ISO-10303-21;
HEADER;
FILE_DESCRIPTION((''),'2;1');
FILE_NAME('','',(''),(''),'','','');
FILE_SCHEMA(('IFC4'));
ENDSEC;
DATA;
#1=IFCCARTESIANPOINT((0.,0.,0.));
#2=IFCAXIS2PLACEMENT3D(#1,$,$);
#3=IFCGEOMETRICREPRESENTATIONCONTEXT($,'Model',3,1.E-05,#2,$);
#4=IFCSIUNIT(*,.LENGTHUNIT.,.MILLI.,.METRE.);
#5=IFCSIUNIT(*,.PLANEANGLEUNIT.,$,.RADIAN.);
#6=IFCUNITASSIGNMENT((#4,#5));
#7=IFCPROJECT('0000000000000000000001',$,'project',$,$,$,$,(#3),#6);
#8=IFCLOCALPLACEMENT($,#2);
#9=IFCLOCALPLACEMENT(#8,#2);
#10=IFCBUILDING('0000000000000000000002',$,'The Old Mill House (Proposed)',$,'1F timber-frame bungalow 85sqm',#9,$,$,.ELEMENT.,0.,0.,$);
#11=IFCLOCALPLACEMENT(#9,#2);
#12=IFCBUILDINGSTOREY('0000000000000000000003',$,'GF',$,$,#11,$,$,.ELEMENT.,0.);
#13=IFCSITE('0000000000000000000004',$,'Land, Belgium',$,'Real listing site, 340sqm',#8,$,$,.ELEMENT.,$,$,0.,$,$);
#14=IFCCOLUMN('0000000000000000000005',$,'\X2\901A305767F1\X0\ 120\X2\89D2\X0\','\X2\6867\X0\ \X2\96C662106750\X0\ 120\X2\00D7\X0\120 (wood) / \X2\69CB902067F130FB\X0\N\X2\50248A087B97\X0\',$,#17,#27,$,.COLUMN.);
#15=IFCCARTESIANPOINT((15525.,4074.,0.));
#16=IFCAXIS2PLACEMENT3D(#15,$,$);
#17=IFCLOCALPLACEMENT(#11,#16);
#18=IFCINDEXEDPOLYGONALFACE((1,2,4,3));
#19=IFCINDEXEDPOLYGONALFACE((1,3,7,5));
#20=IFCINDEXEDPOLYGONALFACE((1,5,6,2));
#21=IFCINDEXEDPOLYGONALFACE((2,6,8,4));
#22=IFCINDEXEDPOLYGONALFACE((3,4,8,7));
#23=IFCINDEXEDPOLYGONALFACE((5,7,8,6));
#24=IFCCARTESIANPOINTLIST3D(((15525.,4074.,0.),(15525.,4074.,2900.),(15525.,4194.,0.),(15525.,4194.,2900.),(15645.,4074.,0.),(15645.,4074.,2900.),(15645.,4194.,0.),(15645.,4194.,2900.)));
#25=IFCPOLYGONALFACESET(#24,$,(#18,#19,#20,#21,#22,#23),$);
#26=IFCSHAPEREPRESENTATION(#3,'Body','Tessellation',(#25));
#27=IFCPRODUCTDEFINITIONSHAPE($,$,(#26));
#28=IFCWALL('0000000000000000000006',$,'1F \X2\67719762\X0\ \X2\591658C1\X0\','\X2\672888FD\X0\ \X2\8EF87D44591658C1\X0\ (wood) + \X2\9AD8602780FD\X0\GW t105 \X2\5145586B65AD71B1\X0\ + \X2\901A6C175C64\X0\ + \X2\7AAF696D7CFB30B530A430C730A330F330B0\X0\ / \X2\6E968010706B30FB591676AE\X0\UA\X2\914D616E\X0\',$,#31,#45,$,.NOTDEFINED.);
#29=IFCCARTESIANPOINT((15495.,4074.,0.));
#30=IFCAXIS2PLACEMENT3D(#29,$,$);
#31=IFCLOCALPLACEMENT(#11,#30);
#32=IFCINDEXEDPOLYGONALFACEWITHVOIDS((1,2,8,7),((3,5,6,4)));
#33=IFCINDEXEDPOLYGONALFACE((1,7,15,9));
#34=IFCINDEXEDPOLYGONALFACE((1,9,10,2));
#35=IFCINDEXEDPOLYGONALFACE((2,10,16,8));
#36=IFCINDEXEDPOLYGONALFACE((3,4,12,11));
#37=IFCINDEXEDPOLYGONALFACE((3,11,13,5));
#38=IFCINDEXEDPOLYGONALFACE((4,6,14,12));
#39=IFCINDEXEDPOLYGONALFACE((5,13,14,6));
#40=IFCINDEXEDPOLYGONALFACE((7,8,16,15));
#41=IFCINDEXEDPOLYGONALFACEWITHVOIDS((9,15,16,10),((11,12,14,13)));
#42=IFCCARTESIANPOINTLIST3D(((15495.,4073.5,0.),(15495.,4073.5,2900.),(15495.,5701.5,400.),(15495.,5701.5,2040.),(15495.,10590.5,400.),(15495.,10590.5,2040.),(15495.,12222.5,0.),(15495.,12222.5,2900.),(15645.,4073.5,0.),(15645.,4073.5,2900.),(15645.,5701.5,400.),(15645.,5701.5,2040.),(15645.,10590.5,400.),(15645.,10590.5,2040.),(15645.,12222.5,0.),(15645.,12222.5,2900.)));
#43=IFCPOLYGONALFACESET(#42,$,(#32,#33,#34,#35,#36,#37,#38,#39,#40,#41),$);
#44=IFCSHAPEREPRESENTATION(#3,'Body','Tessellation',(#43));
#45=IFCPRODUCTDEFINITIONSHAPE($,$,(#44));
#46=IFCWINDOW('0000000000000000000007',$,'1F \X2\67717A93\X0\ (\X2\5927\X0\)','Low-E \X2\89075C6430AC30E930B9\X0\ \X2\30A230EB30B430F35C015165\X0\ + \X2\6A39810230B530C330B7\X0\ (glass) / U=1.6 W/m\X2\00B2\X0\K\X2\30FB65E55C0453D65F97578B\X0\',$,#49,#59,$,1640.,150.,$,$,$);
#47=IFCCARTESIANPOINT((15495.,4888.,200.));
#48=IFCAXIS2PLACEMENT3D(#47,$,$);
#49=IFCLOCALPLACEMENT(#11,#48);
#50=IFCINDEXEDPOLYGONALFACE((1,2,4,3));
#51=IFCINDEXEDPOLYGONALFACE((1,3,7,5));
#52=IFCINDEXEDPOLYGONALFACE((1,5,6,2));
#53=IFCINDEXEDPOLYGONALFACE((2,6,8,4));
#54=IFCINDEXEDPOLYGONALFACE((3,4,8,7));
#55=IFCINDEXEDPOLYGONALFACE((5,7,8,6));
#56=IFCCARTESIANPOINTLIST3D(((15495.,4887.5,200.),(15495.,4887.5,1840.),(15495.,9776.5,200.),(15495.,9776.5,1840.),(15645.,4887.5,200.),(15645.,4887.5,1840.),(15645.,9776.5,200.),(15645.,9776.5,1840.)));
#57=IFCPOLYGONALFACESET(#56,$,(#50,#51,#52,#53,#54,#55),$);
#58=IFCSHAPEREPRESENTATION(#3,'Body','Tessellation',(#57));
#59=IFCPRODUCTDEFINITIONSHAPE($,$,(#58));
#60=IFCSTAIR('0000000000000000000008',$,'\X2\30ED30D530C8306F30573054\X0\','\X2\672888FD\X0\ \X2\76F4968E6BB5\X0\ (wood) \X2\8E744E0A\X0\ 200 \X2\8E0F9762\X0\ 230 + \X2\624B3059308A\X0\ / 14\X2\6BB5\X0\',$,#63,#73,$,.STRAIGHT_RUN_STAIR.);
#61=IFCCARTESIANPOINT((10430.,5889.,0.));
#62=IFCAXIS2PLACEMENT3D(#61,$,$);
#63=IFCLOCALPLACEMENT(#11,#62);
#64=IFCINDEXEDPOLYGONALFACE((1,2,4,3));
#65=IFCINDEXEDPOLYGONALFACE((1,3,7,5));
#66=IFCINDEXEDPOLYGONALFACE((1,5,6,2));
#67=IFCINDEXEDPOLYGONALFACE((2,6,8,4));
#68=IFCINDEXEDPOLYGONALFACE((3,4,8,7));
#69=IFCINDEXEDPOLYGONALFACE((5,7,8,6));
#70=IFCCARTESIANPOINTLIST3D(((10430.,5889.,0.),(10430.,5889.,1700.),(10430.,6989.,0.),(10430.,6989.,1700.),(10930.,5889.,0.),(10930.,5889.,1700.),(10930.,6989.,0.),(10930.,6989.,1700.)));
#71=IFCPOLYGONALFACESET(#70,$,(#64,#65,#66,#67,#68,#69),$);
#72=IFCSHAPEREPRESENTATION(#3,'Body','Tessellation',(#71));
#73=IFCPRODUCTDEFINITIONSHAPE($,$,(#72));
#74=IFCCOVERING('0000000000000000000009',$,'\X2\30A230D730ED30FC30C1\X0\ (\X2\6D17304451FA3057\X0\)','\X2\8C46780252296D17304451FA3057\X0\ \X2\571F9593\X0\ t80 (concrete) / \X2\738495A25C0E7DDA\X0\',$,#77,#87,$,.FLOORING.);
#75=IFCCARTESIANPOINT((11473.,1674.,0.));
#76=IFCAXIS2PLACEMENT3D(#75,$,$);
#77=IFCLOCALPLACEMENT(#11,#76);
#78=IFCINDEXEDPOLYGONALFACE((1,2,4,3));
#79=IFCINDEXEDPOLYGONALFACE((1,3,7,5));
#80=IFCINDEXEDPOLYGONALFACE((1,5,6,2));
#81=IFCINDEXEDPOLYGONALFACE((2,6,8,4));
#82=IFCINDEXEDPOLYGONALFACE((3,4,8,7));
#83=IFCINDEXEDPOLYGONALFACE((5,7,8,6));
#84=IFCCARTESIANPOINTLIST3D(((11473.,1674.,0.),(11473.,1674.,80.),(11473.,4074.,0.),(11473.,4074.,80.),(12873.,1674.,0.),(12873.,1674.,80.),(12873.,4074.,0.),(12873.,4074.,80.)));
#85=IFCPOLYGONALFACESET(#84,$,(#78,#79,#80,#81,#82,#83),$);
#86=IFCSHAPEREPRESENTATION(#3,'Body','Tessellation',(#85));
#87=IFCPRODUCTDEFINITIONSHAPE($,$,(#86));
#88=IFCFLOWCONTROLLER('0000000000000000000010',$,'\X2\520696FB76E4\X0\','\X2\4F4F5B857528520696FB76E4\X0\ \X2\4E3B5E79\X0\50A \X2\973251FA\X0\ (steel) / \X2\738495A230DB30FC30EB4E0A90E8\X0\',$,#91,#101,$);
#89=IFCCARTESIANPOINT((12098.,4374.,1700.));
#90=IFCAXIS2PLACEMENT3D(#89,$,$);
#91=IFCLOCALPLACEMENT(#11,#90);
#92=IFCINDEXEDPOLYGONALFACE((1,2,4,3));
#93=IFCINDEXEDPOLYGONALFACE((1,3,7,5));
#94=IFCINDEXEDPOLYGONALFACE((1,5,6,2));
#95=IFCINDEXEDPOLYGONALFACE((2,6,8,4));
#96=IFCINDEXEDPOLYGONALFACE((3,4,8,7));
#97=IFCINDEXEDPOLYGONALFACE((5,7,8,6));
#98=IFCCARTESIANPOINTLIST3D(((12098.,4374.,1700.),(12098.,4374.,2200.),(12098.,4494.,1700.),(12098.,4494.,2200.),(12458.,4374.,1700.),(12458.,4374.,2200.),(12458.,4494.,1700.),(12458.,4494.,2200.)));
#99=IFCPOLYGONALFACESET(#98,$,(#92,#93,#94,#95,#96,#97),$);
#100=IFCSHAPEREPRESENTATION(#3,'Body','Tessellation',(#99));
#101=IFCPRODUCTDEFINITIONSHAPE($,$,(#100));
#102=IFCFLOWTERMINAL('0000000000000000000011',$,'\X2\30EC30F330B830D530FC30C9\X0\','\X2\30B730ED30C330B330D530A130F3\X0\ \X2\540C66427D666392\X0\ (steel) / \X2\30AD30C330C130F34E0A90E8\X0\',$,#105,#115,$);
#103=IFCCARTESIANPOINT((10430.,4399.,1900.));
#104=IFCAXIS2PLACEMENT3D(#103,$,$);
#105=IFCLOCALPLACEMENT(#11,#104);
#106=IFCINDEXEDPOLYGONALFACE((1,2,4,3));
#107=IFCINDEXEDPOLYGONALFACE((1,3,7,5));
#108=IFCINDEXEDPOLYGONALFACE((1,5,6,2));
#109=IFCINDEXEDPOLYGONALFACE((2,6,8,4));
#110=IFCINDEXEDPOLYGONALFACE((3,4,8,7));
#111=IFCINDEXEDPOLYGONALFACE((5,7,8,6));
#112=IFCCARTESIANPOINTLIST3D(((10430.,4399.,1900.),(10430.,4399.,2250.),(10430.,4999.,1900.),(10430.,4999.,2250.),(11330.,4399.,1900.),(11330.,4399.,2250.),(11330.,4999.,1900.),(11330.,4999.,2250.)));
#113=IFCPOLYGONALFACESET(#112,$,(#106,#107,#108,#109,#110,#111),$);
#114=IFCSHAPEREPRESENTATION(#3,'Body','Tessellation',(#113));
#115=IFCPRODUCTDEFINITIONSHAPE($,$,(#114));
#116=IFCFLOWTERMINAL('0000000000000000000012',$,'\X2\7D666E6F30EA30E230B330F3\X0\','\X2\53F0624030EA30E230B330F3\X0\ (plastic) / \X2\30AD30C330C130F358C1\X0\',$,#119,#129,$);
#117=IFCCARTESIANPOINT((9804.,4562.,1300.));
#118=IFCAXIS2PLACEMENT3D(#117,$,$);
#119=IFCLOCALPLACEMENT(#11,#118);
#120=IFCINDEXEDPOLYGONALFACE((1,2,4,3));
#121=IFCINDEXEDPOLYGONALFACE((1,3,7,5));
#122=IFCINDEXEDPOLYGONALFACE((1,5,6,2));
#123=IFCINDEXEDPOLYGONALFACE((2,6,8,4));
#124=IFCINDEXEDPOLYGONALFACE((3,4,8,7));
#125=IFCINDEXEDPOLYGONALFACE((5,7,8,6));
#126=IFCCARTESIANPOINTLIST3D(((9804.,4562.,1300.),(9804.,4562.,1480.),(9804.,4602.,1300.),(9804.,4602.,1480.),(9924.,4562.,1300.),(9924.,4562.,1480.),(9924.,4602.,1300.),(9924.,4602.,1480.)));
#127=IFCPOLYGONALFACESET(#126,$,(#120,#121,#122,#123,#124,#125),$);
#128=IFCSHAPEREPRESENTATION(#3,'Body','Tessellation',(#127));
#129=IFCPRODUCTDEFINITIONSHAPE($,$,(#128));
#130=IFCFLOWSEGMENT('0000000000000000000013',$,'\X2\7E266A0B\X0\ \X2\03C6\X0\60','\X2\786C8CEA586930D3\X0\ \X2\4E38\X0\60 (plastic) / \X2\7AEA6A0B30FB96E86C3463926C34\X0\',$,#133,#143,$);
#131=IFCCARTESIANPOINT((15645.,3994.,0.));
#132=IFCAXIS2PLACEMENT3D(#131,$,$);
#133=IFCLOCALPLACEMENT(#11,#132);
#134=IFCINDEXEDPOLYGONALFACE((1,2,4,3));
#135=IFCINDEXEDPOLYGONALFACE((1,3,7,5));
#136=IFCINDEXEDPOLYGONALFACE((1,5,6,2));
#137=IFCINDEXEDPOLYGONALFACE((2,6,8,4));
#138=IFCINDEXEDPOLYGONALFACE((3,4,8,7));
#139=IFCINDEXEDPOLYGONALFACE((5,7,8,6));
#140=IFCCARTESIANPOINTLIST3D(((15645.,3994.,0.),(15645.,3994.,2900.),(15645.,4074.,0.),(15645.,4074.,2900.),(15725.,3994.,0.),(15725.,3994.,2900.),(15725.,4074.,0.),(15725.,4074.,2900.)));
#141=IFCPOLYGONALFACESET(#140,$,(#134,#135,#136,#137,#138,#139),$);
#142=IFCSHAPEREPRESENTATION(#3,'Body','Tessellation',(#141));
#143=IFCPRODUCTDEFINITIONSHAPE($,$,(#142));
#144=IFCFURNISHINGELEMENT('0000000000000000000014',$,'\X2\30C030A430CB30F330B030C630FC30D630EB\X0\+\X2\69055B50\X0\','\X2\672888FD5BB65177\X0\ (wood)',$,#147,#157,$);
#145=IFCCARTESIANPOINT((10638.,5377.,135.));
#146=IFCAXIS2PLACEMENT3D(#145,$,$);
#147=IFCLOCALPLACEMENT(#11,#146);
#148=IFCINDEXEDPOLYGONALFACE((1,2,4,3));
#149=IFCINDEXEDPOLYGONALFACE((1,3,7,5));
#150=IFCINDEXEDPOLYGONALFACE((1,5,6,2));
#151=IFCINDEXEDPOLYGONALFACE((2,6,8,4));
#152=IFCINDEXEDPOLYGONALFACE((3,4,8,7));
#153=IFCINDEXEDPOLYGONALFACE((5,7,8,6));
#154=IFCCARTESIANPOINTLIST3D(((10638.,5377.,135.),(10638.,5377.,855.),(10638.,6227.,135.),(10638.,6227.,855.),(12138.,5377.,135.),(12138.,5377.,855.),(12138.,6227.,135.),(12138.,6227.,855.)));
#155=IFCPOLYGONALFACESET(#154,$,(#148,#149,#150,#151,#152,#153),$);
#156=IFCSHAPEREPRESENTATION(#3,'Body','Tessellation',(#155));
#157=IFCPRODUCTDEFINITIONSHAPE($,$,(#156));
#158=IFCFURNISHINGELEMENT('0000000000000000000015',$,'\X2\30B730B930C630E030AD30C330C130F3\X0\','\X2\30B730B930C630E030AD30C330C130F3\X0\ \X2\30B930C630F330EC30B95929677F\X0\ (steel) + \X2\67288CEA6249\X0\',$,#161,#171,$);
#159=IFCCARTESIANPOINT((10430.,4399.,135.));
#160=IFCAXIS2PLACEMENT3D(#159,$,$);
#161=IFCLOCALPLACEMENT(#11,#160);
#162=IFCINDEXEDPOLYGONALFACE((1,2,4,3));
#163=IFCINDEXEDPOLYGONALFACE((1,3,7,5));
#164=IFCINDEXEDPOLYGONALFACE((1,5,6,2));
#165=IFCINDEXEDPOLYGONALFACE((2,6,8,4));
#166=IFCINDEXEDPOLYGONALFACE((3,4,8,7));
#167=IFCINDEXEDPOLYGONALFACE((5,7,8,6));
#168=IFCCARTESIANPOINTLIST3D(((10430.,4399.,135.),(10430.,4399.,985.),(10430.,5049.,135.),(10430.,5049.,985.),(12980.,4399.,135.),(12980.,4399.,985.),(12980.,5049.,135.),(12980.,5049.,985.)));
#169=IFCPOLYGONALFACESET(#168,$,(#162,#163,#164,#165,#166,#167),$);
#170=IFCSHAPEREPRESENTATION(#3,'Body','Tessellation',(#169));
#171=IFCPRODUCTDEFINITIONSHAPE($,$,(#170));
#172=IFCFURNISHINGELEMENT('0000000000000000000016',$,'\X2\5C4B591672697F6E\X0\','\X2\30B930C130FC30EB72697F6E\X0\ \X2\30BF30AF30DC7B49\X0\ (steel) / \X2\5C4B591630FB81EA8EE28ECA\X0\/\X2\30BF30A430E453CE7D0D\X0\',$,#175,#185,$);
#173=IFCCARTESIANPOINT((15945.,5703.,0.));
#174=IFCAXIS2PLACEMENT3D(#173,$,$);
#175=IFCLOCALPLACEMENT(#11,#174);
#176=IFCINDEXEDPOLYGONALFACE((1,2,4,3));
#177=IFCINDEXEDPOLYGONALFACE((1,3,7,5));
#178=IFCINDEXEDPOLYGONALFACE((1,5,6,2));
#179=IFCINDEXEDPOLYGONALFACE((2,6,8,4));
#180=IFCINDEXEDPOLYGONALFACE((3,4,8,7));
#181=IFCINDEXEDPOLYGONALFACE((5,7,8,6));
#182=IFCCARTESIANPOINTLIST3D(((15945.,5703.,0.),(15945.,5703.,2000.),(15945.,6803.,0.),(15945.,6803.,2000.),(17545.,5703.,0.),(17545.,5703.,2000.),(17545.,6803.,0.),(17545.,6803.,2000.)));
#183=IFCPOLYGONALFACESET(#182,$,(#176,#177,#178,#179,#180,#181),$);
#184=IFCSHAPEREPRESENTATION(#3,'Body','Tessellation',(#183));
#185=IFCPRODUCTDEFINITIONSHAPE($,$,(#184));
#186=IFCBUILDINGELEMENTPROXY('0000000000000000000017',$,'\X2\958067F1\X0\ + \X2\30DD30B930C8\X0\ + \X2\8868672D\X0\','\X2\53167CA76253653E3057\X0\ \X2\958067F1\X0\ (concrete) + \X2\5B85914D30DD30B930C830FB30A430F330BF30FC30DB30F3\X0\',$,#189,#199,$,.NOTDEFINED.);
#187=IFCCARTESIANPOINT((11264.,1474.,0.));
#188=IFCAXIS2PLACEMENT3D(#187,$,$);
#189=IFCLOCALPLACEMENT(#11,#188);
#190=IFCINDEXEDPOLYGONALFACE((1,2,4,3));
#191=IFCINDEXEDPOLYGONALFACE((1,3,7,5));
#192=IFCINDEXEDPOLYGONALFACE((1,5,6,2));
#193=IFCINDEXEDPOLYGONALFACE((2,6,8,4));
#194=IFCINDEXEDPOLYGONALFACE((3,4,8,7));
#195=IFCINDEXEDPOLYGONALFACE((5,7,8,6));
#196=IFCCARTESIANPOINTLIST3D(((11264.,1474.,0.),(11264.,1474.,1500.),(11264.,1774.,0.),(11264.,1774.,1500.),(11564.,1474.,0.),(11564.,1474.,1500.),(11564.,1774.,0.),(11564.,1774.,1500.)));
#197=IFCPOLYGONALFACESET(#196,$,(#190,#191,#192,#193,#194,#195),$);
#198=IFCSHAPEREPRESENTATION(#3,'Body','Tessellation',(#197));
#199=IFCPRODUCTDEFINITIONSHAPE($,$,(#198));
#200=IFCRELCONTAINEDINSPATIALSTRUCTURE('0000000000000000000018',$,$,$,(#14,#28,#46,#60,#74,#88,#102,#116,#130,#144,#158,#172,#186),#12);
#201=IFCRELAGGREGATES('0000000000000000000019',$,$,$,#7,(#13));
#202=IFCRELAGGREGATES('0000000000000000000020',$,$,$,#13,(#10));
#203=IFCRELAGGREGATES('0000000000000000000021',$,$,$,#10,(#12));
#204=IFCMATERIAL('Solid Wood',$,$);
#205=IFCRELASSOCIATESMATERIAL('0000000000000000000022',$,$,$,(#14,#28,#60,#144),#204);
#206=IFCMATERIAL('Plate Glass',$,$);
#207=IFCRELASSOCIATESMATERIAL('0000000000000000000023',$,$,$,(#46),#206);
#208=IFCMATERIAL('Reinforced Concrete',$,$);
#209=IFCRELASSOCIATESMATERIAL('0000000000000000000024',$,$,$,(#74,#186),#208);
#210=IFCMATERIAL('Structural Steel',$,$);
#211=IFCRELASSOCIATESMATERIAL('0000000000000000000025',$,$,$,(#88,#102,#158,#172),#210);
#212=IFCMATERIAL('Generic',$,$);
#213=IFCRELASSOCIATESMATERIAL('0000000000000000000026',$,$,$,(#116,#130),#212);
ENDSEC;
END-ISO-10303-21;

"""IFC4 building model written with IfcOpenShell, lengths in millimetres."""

from ifc_helpers import new_model, si_unit, frame, frame_2d, origin, place, context, project, spatial, rectangle, extrude, material, element, fill, save


model = new_model("IFC4")

# Units and contexts
model_context = context("Model", 3, precision=1e-05, world=origin())
ifc_project = project(units=[si_unit("LENGTHUNIT", "METRE", prefix="MILLI"), si_unit("PLANEANGLEUNIT", "RADIAN")], contexts=[model_context])

# Site, building, storey
site_placement = place(None, origin())
site = spatial("IfcSite", under=ifc_project, at=site_placement, Name="Land, Belgium", ObjectType="Real listing site, 340sqm", CompositionType="ELEMENT", RefElevation=0.0)
building_placement = place(site_placement, origin())
building = spatial("IfcBuilding", under=site, at=building_placement, Name="The Old Mill House (Proposed)", ObjectType="1F timber-frame bungalow 85sqm", CompositionType="ELEMENT", ElevationOfRefHeight=0.0, ElevationOfTerrain=0.0)
storey_placement = place(building_placement, origin())
storey = spatial("IfcBuildingStorey", under=building, at=storey_placement, Name="GF", CompositionType="ELEMENT", Elevation=0.0)

# Column
ifc_material_1 = material(Name="Solid Wood")
column_1_placement = place(storey_placement, frame((15525.0, 4074.0, 0.0)))
element("IfcColumn", 1, at=column_1_placement, inside=storey, material=ifc_material_1, Name="通し柱 120角", Description="桧 集成材 120×120 (wood) / 構造柱・N値計算", PredefinedType="COLUMN", context=model_context, shape_type="SweptSolid", body=[
    extrude(rectangle(XDim=120.0, YDim=120.0, at=frame_2d((60.0, 60.0))), frame((15525.0, 4074.0, 0.0)), (0.0, 0.0, 1.0), 2900.0),
])

# Wall, opening, window
wall_1_placement = place(storey_placement, frame((15495.0, 4074.0, 0.0)))
wall_1 = element("IfcWall", 2, at=wall_1_placement, inside=storey, material=ifc_material_1, Name="1F 東面 外壁", Description="木製 軸組外壁 (wood) + 高性能GW t105 充填断熱 + 通気層 + 窯業系サイディング / 準耐火・外皮UA配慮", PredefinedType="NOTDEFINED", context=model_context, shape_type="SweptSolid", body=[
    extrude(rectangle(XDim=150.0, YDim=8149.0, at=frame_2d((75.0, 4074.0))), frame((15495.0, 4074.0, 0.0)), (0.0, 0.0, 1.0), 2900.0),
])
opening_placement = place(storey_placement, frame((15495.0, 4888.0, 200.0)))
opening = element("IfcOpeningElement", 3, at=opening_placement, cuts=wall_1, PredefinedType="NOTDEFINED", context=model_context, shape_type="SweptSolid", body=[
    extrude(rectangle(XDim=150.0, YDim=4889.0, at=frame_2d((75.0, 2444.0))), frame((15495.0, 4888.0, 200.0)), (0.0, 0.0, 1.0), 1640.0),
])
ifc_material_2 = material(Name="Plate Glass")
window_placement = place(storey_placement, frame((15495.0, 4888.0, 200.0)))
window = element("IfcWindow", 4, at=window_placement, inside=storey, material=ifc_material_2, Name="1F 東窓 (大)", Description="Low-E 複層ガラス アルゴン封入 + 樹脂サッシ (glass) / U=1.6 W/m²K・日射取得型", OverallHeight=1640.0, OverallWidth=150.0, context=model_context, shape_type="SweptSolid", body=[
    extrude(rectangle(XDim=150.0, YDim=4889.0, at=frame_2d((75.0, 2444.0))), frame((15495.0, 4888.0, 200.0)), (0.0, 0.0, 1.0), 1640.0),
])
fill(opening, window)

# Stair
stair_placement = place(storey_placement, frame((10430.0, 5889.0, 0.0)))
element("IfcStair", 5, at=stair_placement, inside=storey, material=ifc_material_1, Name="ロフトはしご", Description="木製 直階段 (wood) 蹴上 200 踏面 230 + 手すり / 14段", PredefinedType="STRAIGHT_RUN_STAIR", context=model_context, shape_type="SweptSolid", body=[
    extrude(rectangle(XDim=500.0, YDim=1100.0, at=frame_2d((250.0, 550.0))), frame((10430.0, 5889.0, 0.0)), (0.0, 0.0, 1.0), 1700.0),
])

# Covering
ifc_material_3 = material(Name="Reinforced Concrete")
covering_placement = place(storey_placement, frame((11473.0, 1674.0, 0.0)))
element("IfcCovering", 6, at=covering_placement, inside=storey, material=ifc_material_3, Name="アプローチ (洗い出し)", Description="豆砂利洗い出し 土間 t80 (concrete) / 玄関導線", PredefinedType="FLOORING", context=model_context, shape_type="SweptSolid", body=[
    extrude(rectangle(XDim=1400.0, YDim=2400.0, at=frame_2d((700.0, 1200.0))), frame((11473.0, 1674.0, 0.0)), (0.0, 0.0, 1.0), 80.0),
])

# Flow controller
ifc_material_4 = material(Name="Structural Steel")
flow_controller_placement = place(storey_placement, frame((12098.0, 4374.0, 1700.0)))
element("IfcFlowController", 7, at=flow_controller_placement, inside=storey, material=ifc_material_4, Name="分電盤", Description="住宅用分電盤 主幹50A 露出 (steel) / 玄関ホール上部", context=model_context, shape_type="SweptSolid", body=[
    extrude(rectangle(XDim=360.0, YDim=120.0, at=frame_2d((180.0, 60.0))), frame((12098.0, 4374.0, 1700.0)), (0.0, 0.0, 1.0), 500.0),
])

# Flow terminals
flow_terminal_1_placement = place(storey_placement, frame((10430.0, 4399.0, 1900.0)))
element("IfcFlowTerminal", 8, at=flow_terminal_1_placement, inside=storey, material=ifc_material_4, Name="レンジフード", Description="シロッコファン 同時給排 (steel) / キッチン上部", context=model_context, shape_type="SweptSolid", body=[
    extrude(rectangle(XDim=900.0, YDim=600.0, at=frame_2d((450.0, 300.0))), frame((10430.0, 4399.0, 1900.0)), (0.0, 0.0, 1.0), 350.0),
])
ifc_material_5 = material(Name="Generic")
flow_terminal_2_placement = place(storey_placement, frame((9804.0, 4562.0, 1300.0)))
element("IfcFlowTerminal", 9, at=flow_terminal_2_placement, inside=storey, material=ifc_material_5, Name="給湯リモコン", Description="台所リモコン (plastic) / キッチン壁", context=model_context, shape_type="SweptSolid", body=[
    extrude(rectangle(XDim=120.0, YDim=40.0, at=frame_2d((60.0, 20.0))), frame((9804.0, 4562.0, 1300.0)), (0.0, 0.0, 1.0), 180.0),
])

# Flow segment
flow_segment_placement = place(storey_placement, frame((15645.0, 3994.0, 0.0)))
element("IfcFlowSegment", 10, at=flow_segment_placement, inside=storey, material=ifc_material_5, Name="縦樋 φ60", Description="硬質塩ビ 丸60 (plastic) / 竪樋・雨水排水", context=model_context, shape_type="SweptSolid", body=[
    extrude(rectangle(XDim=80.0, YDim=80.0, at=frame_2d((40.0, 40.0))), frame((15645.0, 3994.0, 0.0)), (0.0, 0.0, 1.0), 2900.0),
])

# Furnishing elements
furnishing_1_placement = place(storey_placement, frame((10638.0, 5377.0, 135.0)))
element("IfcFurnishingElement", 11, at=furnishing_1_placement, inside=storey, material=ifc_material_1, Name="ダイニングテーブル+椅子", Description="木製家具 (wood)", context=model_context, shape_type="SweptSolid", body=[
    extrude(rectangle(XDim=1500.0, YDim=850.0, at=frame_2d((750.0, 425.0))), frame((10638.0, 5377.0, 135.0)), (0.0, 0.0, 1.0), 720.0),
])
furnishing_2_placement = place(storey_placement, frame((10430.0, 4399.0, 135.0)))
element("IfcFurnishingElement", 12, at=furnishing_2_placement, inside=storey, material=ifc_material_4, Name="システムキッチン", Description="システムキッチン ステンレス天板 (steel) + 木質扉", context=model_context, shape_type="SweptSolid", body=[
    extrude(rectangle(XDim=2550.0, YDim=650.0, at=frame_2d((1275.0, 325.0))), frame((10430.0, 4399.0, 135.0)), (0.0, 0.0, 1.0), 850.0),
])
furnishing_3_placement = place(storey_placement, frame((15945.0, 5703.0, 0.0)))
element("IfcFurnishingElement", 13, at=furnishing_3_placement, inside=storey, material=ifc_material_4, Name="屋外物置", Description="スチール物置 タクボ等 (steel) / 屋外・自転車/タイヤ収納", context=model_context, shape_type="SweptSolid", body=[
    extrude(rectangle(XDim=1600.0, YDim=1100.0, at=frame_2d((800.0, 550.0))), frame((15945.0, 5703.0, 0.0)), (0.0, 0.0, 1.0), 2000.0),
])

# Building element proxy
proxy_placement = place(storey_placement, frame((11264.0, 1474.0, 0.0)))
element("IfcBuildingElementProxy", 14, at=proxy_placement, inside=storey, material=ifc_material_3, Name="門柱 + ポスト + 表札", Description="化粧打放し 門柱 (concrete) + 宅配ポスト・インターホン", PredefinedType="NOTDEFINED", context=model_context, shape_type="SweptSolid", body=[
    extrude(rectangle(XDim=300.0, YDim=300.0, at=frame_2d((150.0, 150.0))), frame((11264.0, 1474.0, 0.0)), (0.0, 0.0, 1.0), 1500.0),
])

save(model, "model.ifc")
